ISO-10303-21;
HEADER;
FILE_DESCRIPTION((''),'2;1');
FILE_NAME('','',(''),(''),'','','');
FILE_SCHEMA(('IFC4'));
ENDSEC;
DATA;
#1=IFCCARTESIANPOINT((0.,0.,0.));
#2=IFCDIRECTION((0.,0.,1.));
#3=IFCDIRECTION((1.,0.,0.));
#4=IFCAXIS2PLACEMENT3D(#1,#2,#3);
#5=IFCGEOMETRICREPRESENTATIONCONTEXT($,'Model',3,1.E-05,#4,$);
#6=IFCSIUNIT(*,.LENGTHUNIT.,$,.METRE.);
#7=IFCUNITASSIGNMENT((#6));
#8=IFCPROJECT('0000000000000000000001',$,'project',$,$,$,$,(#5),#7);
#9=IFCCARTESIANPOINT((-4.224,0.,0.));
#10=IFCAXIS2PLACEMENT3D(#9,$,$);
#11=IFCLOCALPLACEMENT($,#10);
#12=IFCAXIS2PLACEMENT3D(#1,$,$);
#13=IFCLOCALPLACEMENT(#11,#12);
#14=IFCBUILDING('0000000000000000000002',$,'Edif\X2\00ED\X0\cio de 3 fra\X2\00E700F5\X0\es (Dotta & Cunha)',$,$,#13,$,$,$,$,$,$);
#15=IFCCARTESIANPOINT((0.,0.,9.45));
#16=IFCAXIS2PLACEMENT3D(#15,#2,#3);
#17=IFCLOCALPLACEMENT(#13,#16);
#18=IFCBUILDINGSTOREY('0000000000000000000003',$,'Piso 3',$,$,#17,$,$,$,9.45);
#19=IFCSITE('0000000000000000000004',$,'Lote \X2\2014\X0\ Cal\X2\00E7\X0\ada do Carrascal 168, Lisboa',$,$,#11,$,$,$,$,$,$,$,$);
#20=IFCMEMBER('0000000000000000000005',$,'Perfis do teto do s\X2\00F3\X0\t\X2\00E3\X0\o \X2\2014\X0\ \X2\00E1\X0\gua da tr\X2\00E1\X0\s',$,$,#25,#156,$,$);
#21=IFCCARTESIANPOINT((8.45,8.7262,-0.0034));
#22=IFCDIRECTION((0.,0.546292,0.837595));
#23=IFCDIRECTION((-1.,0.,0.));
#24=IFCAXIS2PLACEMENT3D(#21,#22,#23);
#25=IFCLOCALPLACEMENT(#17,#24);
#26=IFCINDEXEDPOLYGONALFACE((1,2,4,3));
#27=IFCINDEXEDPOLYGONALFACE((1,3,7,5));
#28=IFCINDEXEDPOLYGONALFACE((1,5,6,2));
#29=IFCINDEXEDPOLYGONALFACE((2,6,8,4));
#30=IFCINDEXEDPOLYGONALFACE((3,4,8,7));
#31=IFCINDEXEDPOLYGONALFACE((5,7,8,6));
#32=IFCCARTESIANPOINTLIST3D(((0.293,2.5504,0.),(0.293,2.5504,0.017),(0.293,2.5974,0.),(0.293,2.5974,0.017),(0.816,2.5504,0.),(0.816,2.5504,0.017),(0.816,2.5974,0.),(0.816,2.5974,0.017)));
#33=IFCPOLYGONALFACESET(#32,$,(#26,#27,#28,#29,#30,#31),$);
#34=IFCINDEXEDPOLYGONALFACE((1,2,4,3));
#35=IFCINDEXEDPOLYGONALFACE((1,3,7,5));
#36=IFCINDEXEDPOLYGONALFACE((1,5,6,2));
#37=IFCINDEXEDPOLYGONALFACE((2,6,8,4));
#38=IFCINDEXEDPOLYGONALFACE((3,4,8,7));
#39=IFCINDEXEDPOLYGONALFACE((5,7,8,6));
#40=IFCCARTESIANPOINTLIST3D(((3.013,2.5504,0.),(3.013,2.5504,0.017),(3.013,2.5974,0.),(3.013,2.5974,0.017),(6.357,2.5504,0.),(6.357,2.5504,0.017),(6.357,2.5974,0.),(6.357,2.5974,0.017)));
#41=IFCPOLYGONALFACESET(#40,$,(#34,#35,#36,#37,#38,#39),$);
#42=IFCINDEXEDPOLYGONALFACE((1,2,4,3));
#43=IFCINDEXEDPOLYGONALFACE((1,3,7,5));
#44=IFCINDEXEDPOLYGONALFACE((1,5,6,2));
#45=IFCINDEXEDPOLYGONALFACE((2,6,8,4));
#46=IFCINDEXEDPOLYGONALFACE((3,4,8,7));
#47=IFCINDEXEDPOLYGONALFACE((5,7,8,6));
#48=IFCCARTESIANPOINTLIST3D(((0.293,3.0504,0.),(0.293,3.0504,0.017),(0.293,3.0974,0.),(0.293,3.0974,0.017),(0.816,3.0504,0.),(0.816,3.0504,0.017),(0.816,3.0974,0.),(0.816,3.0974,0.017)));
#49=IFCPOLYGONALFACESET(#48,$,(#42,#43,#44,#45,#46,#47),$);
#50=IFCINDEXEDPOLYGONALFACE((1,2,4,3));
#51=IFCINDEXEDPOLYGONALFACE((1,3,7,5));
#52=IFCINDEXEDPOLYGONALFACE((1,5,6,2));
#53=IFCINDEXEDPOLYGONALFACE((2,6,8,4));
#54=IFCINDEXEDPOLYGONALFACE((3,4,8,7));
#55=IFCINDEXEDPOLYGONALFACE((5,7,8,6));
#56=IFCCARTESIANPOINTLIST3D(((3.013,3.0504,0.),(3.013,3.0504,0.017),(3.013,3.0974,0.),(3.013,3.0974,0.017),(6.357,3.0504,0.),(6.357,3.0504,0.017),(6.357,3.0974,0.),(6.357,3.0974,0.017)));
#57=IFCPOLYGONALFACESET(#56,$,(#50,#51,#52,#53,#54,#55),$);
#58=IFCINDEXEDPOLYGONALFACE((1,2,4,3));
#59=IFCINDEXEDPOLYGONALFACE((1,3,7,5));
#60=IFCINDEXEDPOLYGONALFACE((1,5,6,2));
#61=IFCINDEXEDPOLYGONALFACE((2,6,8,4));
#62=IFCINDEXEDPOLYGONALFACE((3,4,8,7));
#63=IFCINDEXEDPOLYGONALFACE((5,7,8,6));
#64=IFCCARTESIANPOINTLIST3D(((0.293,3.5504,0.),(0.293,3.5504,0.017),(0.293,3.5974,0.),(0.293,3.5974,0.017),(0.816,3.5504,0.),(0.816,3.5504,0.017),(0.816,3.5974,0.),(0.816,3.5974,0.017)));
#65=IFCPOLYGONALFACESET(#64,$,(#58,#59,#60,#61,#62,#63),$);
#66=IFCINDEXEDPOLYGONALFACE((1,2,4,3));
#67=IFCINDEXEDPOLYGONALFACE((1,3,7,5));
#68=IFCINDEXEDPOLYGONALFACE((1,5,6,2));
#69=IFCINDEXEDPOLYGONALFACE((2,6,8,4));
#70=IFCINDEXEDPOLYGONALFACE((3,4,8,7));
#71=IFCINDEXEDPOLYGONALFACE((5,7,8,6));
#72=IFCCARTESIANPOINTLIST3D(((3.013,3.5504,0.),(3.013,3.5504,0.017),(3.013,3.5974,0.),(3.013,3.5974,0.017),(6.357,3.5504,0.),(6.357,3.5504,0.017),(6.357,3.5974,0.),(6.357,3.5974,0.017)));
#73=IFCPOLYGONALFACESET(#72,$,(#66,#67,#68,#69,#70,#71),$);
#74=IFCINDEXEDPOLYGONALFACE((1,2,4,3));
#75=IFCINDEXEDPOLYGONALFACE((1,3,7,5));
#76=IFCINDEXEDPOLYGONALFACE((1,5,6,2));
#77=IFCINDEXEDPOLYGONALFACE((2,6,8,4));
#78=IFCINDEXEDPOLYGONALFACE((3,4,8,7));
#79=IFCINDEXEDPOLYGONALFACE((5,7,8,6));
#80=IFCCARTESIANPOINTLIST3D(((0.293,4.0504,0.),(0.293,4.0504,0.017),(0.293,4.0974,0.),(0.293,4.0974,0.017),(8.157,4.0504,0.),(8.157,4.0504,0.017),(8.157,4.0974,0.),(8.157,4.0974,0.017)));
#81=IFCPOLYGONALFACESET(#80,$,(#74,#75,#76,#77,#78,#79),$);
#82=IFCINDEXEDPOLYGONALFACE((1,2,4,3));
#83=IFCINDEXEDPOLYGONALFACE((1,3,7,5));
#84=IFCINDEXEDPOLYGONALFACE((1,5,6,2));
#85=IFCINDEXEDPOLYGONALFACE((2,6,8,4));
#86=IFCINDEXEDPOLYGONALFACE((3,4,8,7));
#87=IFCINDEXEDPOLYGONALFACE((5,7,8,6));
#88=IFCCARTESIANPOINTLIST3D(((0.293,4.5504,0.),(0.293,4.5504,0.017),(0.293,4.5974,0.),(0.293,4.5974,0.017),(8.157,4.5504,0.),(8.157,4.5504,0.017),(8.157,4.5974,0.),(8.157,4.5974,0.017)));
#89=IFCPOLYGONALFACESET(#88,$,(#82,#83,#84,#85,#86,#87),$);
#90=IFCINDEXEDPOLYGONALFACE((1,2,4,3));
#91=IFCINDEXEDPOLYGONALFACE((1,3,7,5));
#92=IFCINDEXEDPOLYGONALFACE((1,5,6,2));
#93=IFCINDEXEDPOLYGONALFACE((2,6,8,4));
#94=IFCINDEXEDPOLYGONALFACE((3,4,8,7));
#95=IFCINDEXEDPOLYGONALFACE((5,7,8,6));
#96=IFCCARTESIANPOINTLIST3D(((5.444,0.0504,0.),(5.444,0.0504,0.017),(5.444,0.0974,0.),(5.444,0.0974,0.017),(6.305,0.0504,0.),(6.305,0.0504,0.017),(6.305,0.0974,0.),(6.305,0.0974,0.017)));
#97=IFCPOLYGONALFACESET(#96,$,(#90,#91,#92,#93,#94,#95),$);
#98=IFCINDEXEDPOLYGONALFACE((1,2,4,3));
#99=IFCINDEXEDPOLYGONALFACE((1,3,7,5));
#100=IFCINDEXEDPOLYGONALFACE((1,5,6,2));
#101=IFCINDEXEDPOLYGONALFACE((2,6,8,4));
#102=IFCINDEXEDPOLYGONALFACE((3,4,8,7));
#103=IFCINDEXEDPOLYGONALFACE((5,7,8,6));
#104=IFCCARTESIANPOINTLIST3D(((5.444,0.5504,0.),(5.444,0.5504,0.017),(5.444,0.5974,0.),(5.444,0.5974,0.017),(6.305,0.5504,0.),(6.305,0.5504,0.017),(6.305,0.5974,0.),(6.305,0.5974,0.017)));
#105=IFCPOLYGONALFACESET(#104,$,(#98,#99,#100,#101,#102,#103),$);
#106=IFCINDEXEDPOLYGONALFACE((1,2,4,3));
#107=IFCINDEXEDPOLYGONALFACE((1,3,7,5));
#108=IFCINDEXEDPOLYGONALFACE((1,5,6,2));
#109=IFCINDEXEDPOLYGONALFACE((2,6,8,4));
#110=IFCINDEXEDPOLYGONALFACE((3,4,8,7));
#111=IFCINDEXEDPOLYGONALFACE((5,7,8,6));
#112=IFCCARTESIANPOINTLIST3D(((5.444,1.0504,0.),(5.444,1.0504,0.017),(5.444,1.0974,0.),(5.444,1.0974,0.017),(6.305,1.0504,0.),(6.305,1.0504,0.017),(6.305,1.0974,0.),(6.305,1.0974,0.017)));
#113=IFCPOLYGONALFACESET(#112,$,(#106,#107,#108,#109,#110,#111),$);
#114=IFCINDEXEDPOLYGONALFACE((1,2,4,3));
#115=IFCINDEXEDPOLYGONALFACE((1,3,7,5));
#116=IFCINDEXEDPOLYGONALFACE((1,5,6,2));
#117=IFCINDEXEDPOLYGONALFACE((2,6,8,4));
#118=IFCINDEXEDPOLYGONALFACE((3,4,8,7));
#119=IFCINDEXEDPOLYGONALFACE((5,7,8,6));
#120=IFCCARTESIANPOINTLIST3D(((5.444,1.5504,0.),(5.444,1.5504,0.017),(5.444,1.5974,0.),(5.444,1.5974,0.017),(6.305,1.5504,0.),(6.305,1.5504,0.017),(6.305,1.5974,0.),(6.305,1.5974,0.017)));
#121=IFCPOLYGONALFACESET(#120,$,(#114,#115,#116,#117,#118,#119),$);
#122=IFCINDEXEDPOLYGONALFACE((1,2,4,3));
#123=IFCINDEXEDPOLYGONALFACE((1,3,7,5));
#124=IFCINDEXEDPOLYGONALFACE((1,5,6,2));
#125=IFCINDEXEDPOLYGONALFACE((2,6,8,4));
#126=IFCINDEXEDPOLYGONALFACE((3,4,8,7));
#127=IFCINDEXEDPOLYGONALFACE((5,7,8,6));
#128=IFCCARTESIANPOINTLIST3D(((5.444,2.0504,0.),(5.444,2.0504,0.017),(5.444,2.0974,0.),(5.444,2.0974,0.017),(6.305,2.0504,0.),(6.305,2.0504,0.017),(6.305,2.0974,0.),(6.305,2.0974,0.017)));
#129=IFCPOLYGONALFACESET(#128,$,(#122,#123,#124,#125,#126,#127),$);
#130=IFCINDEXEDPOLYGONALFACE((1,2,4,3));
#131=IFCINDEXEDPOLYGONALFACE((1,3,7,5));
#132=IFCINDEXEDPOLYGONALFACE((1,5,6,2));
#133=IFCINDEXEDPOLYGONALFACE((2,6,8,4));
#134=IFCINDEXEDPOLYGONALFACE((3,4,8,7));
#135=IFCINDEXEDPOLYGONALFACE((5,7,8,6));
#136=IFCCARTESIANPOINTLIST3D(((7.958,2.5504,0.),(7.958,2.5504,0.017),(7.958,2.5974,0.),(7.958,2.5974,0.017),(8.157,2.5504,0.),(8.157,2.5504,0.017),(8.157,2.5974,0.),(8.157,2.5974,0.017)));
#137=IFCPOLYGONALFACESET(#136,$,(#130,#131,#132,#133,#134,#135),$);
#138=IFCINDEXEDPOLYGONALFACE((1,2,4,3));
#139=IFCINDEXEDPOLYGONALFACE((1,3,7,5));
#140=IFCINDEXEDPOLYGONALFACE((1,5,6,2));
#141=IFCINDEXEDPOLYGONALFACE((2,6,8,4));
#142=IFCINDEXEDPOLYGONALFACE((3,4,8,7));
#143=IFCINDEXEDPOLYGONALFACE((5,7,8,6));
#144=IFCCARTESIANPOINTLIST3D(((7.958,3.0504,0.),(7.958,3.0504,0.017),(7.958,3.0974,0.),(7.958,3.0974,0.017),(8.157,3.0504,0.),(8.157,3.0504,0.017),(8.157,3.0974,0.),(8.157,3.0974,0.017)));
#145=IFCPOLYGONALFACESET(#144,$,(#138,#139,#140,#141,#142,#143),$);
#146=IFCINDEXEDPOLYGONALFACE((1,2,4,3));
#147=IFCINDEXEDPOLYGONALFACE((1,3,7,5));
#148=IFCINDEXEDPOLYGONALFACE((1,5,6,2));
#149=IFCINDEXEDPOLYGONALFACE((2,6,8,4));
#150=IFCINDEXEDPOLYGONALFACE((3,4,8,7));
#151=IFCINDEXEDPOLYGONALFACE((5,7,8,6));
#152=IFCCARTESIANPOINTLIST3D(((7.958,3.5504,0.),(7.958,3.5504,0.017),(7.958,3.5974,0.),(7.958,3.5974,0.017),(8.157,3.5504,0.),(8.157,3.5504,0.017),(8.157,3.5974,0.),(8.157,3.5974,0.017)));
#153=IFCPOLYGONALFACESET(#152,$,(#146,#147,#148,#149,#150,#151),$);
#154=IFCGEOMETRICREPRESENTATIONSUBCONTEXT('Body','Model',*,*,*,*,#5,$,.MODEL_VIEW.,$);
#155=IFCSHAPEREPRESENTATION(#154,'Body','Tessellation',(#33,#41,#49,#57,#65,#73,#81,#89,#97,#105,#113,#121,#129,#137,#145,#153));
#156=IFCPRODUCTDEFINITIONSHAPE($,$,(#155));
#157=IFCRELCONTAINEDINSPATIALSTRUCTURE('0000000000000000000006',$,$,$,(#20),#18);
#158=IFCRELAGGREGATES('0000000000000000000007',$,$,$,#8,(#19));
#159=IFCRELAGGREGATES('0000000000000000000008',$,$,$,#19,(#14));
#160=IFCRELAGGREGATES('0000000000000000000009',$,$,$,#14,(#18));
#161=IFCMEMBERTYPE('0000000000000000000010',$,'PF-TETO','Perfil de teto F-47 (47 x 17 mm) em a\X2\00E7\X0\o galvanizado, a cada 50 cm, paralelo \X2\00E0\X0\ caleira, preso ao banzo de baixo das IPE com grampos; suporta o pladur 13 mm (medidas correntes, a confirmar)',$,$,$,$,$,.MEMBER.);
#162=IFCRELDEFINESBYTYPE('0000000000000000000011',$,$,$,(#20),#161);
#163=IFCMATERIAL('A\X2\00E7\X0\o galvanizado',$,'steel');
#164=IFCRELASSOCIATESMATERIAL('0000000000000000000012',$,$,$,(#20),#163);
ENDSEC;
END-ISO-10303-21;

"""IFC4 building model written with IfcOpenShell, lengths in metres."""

from ifc_helpers import new_model, si_unit, frame, origin, origin_with_axes, place, context, subcontext, project, spatial, line, indexed_curve, outline, extrude, material, type_object, element, save


model = new_model("IFC4")

# Units and contexts
model_context = context("Model", 3, precision=1e-05, world=origin_with_axes())
body_context = subcontext(model_context, "Body", "Model", "MODEL_VIEW")
ifc_project = project(units=[si_unit("LENGTHUNIT", "METRE")], contexts=[model_context])

# Site, building, storey
site_placement = place(None, frame((-4.224, 0.0, 0.0)))
site = spatial("IfcSite", under=ifc_project, at=site_placement, Name="Lote — Calçada do Carrascal 168, Lisboa")
building_placement = place(site_placement, origin())
building = spatial("IfcBuilding", under=site, at=building_placement, Name="Edifício de 3 frações (Dotta & Cunha)")
storey_placement = place(building_placement, frame((0.0, 0.0, 9.45), z_axis=(0.0, 0.0, 1.0), x_axis=(1.0, 0.0, 0.0)))
storey = spatial("IfcBuildingStorey", under=building, at=storey_placement, Name="Piso 3", Elevation=9.45)

# Member
ifc_material_1 = material(Name="Aço galvanizado", Category="steel")
member_type_1 = type_object("IfcMemberType", Name="PF-TETO", Description="Perfil de teto F-47 (47 x 17 mm) em aço galvanizado, a cada 50 cm, paralelo à caleira, preso ao banzo de baixo das IPE com grampos; suporta o pladur 13 mm (medidas correntes, a confirmar)", PredefinedType="MEMBER")
member_1_placement = place(storey_placement, frame((8.45, 8.7262, -0.0034), z_axis=(0.0, 0.546292, 0.837595), x_axis=(-1.0, 0.0, 0.0)))
element("IfcMember", 1, at=member_1_placement, inside=storey, type_object=member_type_1, material=ifc_material_1, Name="Perfis do teto do sótão — água da trás", context=body_context, shape_type="SweptSolid", body=[
    extrude(outline(indexed_curve([(0.816, 2.5974), (0.816, 2.5504), (0.293, 2.5504), (0.293, 2.5974)], segments=[line(1, 2, 3, 4, 1)])), origin_with_axes(), (0.0, 0.0, 1.0), 0.017),
    extrude(outline(indexed_curve([(6.357, 2.5974), (6.357, 2.5504), (3.013, 2.5504), (3.013, 2.5974)], segments=[line(1, 2, 3, 4, 1)])), origin_with_axes(), (0.0, 0.0, 1.0), 0.017),
    extrude(outline(indexed_curve([(0.816, 3.0974), (0.816, 3.0504), (0.293, 3.0504), (0.293, 3.0974)], segments=[line(1, 2, 3, 4, 1)])), origin_with_axes(), (0.0, 0.0, 1.0), 0.017),
    extrude(outline(indexed_curve([(6.357, 3.0974), (6.357, 3.0504), (3.013, 3.0504), (3.013, 3.0974)], segments=[line(1, 2, 3, 4, 1)])), origin_with_axes(), (0.0, 0.0, 1.0), 0.017),
    extrude(outline(indexed_curve([(0.816, 3.5974), (0.816, 3.5504), (0.293, 3.5504), (0.293, 3.5974)], segments=[line(1, 2, 3, 4, 1)])), origin_with_axes(), (0.0, 0.0, 1.0), 0.017),
    extrude(outline(indexed_curve([(6.357, 3.5974), (6.357, 3.5504), (3.013, 3.5504), (3.013, 3.5974)], segments=[line(1, 2, 3, 4, 1)])), origin_with_axes(), (0.0, 0.0, 1.0), 0.017),
    extrude(outline(indexed_curve([(8.157, 4.0974), (8.157, 4.0504), (0.293, 4.0504), (0.293, 4.0974)], segments=[line(1, 2, 3, 4, 1)])), origin_with_axes(), (0.0, 0.0, 1.0), 0.017),
    extrude(outline(indexed_curve([(8.157, 4.5974), (8.157, 4.5504), (0.293, 4.5504), (0.293, 4.5974)], segments=[line(1, 2, 3, 4, 1)])), origin_with_axes(), (0.0, 0.0, 1.0), 0.017),
    extrude(outline(indexed_curve([(6.305, 0.0974), (6.305, 0.0504), (5.444, 0.0504), (5.444, 0.0974)], segments=[line(1, 2, 3, 4, 1)])), origin_with_axes(), (0.0, 0.0, 1.0), 0.017),
    extrude(outline(indexed_curve([(6.305, 0.5974), (6.305, 0.5504), (5.444, 0.5504), (5.444, 0.5974)], segments=[line(1, 2, 3, 4, 1)])), origin_with_axes(), (0.0, 0.0, 1.0), 0.017),
    extrude(outline(indexed_curve([(6.305, 1.0974), (6.305, 1.0504), (5.444, 1.0504), (5.444, 1.0974)], segments=[line(1, 2, 3, 4, 1)])), origin_with_axes(), (0.0, 0.0, 1.0), 0.017),
    extrude(outline(indexed_curve([(6.305, 1.5974), (6.305, 1.5504), (5.444, 1.5504), (5.444, 1.5974)], segments=[line(1, 2, 3, 4, 1)])), origin_with_axes(), (0.0, 0.0, 1.0), 0.017),
    extrude(outline(indexed_curve([(6.305, 2.0974), (6.305, 2.0504), (5.444, 2.0504), (5.444, 2.0974)], segments=[line(1, 2, 3, 4, 1)])), origin_with_axes(), (0.0, 0.0, 1.0), 0.017),
    extrude(outline(indexed_curve([(8.157, 2.5974), (8.157, 2.5504), (7.958, 2.5504), (7.958, 2.5974)], segments=[line(1, 2, 3, 4, 1)])), origin_with_axes(), (0.0, 0.0, 1.0), 0.017),
    extrude(outline(indexed_curve([(8.157, 3.0974), (8.157, 3.0504), (7.958, 3.0504), (7.958, 3.0974)], segments=[line(1, 2, 3, 4, 1)])), origin_with_axes(), (0.0, 0.0, 1.0), 0.017),
    extrude(outline(indexed_curve([(8.157, 3.5974), (8.157, 3.5504), (7.958, 3.5504), (7.958, 3.5974)], segments=[line(1, 2, 3, 4, 1)])), origin_with_axes(), (0.0, 0.0, 1.0), 0.017),
])

save(model, "model.ifc")
